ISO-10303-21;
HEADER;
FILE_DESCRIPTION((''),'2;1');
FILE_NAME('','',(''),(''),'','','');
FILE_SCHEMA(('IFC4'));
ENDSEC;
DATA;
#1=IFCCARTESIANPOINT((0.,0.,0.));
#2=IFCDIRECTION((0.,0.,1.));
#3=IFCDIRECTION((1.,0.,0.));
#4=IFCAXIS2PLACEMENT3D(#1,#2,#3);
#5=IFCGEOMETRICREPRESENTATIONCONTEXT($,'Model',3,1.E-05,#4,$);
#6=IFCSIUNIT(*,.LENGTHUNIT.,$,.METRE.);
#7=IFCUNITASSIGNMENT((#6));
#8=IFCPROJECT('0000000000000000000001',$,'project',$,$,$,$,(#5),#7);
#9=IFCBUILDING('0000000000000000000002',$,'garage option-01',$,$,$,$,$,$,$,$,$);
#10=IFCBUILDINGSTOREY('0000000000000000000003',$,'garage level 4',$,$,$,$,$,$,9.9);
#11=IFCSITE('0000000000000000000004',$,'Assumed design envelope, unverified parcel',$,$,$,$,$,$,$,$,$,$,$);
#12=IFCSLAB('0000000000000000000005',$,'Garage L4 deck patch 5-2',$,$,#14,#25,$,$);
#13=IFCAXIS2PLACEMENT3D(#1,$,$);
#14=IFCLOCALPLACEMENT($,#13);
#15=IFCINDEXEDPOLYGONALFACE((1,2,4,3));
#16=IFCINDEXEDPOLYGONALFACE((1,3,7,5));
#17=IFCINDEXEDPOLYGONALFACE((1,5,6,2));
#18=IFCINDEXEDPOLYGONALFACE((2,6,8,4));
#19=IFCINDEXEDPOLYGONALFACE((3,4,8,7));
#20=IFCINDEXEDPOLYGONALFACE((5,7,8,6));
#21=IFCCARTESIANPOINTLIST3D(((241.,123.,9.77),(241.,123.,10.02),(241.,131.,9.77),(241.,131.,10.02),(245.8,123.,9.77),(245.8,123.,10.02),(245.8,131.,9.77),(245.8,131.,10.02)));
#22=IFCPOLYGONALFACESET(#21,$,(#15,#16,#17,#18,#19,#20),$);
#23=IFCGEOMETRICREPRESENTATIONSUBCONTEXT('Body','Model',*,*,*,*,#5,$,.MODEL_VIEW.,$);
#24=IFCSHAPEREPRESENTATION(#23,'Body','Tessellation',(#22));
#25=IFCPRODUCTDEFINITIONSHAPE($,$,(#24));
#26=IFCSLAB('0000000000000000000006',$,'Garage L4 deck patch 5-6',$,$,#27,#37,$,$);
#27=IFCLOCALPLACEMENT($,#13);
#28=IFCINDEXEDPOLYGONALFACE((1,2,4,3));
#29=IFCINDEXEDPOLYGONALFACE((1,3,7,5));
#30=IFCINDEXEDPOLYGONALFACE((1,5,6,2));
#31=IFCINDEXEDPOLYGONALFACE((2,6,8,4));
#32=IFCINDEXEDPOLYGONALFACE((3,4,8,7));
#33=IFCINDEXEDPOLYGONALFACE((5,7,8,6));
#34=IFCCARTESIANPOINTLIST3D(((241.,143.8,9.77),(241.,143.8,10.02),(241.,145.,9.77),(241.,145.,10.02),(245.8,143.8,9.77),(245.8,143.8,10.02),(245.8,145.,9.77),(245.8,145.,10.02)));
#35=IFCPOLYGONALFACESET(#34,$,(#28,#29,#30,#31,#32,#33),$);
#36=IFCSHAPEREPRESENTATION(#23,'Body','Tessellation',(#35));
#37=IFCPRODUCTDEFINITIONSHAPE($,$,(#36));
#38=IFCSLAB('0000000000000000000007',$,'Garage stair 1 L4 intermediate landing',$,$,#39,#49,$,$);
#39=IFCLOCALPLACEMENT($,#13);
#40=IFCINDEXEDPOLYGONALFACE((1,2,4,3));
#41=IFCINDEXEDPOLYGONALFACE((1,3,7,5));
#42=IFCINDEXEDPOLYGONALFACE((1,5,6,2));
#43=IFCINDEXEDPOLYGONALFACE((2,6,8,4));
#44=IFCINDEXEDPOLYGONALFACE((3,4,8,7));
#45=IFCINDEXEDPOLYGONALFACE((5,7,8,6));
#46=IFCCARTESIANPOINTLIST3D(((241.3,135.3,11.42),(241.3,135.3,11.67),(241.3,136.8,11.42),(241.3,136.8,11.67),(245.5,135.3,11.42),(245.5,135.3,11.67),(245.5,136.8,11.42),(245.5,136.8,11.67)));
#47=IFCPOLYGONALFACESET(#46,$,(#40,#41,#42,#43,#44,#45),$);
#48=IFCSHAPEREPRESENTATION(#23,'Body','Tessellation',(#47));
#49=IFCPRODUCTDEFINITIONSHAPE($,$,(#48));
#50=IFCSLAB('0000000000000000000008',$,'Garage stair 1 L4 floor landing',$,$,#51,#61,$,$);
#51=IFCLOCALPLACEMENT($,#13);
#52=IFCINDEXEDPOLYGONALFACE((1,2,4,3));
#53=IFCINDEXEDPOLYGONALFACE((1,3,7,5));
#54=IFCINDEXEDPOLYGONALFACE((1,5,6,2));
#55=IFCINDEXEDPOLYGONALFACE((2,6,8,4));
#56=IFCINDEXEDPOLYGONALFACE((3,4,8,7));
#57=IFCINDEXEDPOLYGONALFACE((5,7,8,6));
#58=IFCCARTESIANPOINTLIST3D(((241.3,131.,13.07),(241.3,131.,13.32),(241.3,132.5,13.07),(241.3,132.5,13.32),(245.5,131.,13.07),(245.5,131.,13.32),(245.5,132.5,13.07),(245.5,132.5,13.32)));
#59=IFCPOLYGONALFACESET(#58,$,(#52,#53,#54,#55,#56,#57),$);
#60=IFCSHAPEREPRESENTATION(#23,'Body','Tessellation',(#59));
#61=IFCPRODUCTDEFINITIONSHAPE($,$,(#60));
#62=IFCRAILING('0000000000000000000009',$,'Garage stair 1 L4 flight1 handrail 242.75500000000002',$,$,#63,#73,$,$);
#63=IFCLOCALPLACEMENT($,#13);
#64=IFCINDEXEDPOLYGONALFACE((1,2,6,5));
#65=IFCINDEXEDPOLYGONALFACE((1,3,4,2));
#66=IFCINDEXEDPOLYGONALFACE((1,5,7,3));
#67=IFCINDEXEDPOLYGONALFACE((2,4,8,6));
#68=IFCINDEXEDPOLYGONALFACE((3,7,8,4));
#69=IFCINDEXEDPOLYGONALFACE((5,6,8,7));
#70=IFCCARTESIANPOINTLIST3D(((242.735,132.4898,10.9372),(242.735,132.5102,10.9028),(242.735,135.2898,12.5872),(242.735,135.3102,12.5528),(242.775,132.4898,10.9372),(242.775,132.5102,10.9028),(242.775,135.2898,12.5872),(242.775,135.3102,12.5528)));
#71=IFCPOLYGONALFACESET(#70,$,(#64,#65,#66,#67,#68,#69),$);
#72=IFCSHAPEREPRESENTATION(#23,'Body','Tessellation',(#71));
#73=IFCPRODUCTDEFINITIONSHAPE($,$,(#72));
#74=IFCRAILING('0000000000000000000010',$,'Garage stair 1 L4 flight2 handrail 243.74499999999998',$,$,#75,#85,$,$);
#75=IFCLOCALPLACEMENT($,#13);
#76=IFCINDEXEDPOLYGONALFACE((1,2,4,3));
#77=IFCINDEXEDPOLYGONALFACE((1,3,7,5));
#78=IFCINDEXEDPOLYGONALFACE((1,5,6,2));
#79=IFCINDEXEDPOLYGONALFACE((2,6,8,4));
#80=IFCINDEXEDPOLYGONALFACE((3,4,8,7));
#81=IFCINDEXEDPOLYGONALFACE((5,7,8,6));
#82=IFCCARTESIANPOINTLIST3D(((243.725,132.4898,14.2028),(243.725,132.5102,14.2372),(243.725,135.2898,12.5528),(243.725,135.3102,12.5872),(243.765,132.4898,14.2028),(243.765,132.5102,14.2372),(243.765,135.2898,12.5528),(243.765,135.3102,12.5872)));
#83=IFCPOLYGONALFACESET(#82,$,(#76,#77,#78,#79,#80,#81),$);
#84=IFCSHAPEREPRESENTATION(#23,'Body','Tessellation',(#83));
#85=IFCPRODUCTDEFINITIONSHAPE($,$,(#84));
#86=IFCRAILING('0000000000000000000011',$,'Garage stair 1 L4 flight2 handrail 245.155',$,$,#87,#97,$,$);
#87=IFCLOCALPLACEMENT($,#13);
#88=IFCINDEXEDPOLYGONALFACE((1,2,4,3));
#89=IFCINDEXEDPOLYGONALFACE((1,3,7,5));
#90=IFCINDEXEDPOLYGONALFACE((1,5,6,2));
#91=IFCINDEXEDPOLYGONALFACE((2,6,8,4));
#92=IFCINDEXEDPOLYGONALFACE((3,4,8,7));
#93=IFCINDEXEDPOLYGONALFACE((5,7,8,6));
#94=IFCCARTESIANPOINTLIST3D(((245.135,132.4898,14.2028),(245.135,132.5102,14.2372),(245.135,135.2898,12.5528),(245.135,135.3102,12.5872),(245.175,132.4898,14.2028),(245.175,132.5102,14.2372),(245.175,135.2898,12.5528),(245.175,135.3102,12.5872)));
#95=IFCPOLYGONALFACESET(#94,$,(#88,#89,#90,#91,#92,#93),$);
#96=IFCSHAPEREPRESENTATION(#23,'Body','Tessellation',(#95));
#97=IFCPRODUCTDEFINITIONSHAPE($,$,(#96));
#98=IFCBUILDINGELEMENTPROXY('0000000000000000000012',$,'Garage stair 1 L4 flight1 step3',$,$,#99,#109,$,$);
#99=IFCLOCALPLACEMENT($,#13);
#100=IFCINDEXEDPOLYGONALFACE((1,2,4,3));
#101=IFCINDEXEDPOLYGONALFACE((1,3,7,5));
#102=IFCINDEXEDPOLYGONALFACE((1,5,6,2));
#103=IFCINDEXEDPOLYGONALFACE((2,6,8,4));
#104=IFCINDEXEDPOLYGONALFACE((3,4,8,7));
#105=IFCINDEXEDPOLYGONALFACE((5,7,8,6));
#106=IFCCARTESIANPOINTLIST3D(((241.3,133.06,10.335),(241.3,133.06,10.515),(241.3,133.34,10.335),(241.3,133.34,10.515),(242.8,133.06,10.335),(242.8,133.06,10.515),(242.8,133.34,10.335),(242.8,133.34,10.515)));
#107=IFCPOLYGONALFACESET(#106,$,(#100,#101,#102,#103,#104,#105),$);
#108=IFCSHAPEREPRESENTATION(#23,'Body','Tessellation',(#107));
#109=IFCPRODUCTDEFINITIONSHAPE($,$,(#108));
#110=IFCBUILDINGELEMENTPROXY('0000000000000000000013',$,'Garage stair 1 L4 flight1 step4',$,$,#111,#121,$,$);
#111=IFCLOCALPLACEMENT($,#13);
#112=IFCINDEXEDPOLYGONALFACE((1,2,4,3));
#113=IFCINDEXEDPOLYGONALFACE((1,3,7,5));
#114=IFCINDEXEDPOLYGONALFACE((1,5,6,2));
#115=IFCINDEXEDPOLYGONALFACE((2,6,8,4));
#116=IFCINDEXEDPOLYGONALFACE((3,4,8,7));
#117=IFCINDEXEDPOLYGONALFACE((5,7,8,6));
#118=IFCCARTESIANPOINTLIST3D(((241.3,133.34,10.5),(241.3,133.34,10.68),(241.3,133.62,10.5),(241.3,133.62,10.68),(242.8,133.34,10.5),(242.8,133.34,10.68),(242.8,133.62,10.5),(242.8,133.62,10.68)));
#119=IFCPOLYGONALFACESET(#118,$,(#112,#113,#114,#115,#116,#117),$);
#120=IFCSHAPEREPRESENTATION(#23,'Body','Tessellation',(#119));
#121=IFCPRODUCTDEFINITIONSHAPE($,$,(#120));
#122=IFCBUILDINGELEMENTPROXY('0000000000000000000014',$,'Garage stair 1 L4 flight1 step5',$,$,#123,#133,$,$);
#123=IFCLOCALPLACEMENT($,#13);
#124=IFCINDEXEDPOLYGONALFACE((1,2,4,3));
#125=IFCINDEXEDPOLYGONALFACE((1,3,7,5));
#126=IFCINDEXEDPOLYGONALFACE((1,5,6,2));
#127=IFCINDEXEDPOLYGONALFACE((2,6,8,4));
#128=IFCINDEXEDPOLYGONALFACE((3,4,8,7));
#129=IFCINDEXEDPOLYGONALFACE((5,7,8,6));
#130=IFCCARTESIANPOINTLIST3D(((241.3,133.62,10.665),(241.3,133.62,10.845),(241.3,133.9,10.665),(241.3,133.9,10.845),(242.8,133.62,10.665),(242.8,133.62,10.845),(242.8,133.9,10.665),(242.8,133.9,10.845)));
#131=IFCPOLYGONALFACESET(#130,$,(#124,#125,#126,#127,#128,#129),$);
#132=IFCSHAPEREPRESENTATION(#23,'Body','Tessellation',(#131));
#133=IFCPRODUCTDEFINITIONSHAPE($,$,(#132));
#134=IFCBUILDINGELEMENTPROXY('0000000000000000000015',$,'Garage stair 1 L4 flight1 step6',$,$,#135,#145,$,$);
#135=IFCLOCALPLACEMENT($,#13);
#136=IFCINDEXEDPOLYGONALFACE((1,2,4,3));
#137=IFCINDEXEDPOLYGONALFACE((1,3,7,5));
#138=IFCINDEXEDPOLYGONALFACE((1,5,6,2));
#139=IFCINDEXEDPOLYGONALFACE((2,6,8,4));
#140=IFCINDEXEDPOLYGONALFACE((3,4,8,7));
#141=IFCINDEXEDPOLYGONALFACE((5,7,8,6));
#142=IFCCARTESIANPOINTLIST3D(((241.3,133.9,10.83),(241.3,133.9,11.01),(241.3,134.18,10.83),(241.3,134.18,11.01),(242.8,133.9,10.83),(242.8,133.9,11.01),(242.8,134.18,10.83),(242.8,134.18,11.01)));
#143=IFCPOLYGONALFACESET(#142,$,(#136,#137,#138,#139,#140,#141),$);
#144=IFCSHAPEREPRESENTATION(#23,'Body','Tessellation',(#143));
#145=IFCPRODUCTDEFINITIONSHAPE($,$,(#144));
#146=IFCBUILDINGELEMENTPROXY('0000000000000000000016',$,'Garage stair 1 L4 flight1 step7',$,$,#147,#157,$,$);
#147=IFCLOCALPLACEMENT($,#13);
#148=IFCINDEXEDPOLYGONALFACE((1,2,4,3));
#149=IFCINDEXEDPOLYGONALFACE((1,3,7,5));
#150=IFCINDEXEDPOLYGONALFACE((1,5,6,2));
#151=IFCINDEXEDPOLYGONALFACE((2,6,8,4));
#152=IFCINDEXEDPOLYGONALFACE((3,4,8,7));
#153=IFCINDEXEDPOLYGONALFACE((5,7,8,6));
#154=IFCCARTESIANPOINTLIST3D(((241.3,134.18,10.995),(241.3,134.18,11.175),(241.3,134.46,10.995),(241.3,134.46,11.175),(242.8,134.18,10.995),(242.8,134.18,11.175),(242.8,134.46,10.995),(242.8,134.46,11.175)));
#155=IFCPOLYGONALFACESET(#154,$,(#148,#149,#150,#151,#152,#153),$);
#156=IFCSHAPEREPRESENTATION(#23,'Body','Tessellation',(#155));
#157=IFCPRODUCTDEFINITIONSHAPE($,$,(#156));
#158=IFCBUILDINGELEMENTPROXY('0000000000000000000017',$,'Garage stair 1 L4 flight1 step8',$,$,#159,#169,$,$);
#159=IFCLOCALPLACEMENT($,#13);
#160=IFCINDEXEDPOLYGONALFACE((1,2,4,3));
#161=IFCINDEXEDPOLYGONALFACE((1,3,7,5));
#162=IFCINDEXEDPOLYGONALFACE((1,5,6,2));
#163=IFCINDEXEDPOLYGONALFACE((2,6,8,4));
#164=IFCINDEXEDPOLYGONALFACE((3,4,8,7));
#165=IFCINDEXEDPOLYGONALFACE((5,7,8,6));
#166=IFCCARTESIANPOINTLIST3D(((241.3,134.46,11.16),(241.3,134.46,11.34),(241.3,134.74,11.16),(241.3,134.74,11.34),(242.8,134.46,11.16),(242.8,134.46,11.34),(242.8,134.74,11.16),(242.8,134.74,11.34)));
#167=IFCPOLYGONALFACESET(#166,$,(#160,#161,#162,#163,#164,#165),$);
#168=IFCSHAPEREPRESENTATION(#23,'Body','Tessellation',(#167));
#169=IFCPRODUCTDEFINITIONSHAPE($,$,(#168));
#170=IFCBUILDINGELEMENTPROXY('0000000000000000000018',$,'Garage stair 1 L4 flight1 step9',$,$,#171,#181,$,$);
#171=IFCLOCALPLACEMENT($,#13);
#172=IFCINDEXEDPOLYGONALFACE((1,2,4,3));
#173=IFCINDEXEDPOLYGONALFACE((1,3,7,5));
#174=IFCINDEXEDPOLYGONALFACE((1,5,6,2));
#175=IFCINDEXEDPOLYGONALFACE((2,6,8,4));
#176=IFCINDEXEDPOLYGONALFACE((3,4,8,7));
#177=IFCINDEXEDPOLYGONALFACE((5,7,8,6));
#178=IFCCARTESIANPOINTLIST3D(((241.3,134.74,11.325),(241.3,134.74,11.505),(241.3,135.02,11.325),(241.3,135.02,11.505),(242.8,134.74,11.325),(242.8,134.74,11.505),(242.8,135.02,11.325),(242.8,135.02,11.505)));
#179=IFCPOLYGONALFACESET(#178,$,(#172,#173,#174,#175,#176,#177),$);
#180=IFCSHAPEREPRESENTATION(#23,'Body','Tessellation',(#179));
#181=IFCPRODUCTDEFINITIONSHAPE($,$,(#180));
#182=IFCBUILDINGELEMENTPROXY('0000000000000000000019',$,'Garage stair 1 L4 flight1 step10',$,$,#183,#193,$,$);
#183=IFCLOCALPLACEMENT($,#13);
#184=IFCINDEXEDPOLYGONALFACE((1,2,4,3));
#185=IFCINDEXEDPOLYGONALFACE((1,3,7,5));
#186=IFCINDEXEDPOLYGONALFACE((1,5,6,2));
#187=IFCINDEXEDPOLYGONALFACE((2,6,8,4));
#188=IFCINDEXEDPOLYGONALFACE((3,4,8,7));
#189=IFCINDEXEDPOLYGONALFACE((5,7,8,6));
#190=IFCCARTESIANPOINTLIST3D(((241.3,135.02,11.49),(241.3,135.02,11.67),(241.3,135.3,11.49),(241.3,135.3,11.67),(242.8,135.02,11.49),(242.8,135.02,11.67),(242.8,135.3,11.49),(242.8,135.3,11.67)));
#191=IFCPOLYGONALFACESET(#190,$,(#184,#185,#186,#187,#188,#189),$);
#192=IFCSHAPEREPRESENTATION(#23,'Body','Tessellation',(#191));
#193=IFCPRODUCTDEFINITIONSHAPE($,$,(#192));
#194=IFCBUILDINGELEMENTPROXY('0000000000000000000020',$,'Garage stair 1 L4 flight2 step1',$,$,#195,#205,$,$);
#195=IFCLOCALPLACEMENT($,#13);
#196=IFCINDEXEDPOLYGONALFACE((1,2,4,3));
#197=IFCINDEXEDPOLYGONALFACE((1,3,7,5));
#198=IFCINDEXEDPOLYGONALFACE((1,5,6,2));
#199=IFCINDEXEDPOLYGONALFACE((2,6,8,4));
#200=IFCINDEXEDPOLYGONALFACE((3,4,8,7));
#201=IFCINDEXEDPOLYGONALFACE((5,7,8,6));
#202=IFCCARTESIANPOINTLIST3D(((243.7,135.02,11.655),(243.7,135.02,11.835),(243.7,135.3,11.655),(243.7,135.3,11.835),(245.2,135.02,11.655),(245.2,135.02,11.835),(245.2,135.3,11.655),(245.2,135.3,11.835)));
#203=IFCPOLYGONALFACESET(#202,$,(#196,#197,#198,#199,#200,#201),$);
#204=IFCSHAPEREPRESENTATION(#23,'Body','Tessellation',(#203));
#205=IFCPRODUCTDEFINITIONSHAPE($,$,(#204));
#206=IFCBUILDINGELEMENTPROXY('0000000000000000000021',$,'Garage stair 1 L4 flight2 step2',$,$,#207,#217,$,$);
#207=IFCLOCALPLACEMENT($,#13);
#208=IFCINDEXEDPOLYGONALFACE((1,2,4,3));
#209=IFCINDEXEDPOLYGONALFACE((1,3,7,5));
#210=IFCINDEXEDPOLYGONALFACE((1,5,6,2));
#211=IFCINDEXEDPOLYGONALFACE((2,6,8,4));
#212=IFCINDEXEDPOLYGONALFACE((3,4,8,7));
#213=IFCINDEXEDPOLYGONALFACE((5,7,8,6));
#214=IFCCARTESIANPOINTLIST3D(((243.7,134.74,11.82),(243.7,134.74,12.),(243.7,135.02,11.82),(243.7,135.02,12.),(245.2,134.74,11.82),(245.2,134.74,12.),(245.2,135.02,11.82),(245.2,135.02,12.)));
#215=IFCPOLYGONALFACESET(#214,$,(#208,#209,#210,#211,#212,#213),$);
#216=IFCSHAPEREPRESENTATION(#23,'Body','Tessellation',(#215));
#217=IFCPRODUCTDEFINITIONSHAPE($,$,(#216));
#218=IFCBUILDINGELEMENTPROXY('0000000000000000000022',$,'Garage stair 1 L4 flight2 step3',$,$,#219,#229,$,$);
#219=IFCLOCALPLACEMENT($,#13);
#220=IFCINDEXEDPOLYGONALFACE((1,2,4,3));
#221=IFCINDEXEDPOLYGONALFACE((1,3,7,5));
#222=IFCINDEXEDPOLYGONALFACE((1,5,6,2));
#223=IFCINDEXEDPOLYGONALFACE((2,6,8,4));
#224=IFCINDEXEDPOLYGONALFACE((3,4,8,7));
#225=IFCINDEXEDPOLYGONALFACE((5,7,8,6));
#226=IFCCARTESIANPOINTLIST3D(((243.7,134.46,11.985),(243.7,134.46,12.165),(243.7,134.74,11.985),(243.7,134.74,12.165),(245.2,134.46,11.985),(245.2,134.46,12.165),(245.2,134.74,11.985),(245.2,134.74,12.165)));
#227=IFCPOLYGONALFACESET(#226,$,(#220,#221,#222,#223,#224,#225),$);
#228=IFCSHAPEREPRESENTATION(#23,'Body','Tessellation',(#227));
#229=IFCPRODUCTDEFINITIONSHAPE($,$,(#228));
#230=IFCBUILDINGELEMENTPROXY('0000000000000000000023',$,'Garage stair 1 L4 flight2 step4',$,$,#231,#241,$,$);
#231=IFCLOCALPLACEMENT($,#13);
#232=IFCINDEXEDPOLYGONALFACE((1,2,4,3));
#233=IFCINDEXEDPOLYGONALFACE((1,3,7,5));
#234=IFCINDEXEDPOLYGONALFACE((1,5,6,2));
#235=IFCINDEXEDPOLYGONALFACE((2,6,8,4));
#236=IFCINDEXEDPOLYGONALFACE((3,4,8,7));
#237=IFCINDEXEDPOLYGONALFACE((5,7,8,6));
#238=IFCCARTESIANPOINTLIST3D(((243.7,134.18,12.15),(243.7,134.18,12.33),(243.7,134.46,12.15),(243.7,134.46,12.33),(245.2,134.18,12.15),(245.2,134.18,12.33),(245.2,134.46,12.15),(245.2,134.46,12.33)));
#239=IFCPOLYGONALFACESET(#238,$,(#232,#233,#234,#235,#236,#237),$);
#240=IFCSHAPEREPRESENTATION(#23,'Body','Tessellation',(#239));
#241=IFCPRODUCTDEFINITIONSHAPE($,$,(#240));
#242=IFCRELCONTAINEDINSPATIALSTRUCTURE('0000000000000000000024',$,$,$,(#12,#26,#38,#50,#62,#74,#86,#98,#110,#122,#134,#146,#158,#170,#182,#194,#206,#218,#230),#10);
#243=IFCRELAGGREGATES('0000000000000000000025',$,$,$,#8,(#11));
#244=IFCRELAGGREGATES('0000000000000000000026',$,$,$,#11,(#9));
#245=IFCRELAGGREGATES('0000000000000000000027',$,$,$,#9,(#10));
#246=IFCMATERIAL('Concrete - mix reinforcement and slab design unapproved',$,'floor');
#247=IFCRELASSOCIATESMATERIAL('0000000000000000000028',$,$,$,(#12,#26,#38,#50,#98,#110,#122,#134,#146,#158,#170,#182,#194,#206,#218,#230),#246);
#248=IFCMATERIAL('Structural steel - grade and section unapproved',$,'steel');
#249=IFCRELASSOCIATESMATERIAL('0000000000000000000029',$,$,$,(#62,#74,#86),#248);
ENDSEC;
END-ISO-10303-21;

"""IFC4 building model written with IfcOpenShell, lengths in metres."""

from ifc_helpers import new_model, si_unit, frame, origin_with_axes, place, context, subcontext, project, spatial, rectangle, extrude, material, element, save


model = new_model("IFC4")

# Units and contexts
model_context = context("Model", 3, precision=1e-05, world=origin_with_axes())
body_context = subcontext(model_context, "Body", "Model", "MODEL_VIEW")
ifc_project = project(units=[si_unit("LENGTHUNIT", "METRE")], contexts=[model_context])

# Site, building, storey
site = spatial("IfcSite", under=ifc_project, Name="Assumed design envelope, unverified parcel")
building = spatial("IfcBuilding", under=site, Name="garage option-01")
storey = spatial("IfcBuildingStorey", under=building, Name="garage level 4", Elevation=9.9)

# Slabs
ifc_material_1 = material(Name="Concrete - mix reinforcement and slab design unapproved", Category="floor")
slab_1_placement = place(None, frame((243.4, 127.0, 9.77), z_axis=(0.0, 0.0, 1.0), x_axis=(1.0, 0.0, 0.0)))
element("IfcSlab", 1, at=slab_1_placement, inside=storey, material=ifc_material_1, Name="Garage L4 deck patch 5-2", context=body_context, shape_type="SweptSolid", body=[
    extrude(rectangle(XDim=4.8, YDim=8.0), origin_with_axes(), (0.0, 0.0, 1.0), 0.25),
])
slab_2_placement = place(None, frame((243.4, 144.4, 9.77), z_axis=(0.0, 0.0, 1.0), x_axis=(1.0, 0.0, 0.0)))
element("IfcSlab", 2, at=slab_2_placement, inside=storey, material=ifc_material_1, Name="Garage L4 deck patch 5-6", context=body_context, shape_type="SweptSolid", body=[
    extrude(rectangle(XDim=4.8, YDim=1.2), origin_with_axes(), (0.0, 0.0, 1.0), 0.25),
])
for number, where, z_axis, x_axis, name in (
    (3, (243.4, 136.05, 11.42), (0.0, 0.0, 1.0), (1.0, 0.0, 0.0), "Garage stair 1 L4 intermediate landing"),
    (4, (243.4, 131.75, 13.07), (0.0, 0.0, 1.0), (1.0, 0.0, 0.0), "Garage stair 1 L4 floor landing"),
):
    element("IfcSlab", number, at=place(None, frame(where, z_axis=z_axis, x_axis=x_axis)), inside=storey, material=ifc_material_1, Name=name, context=body_context, shape_type="SweptSolid", body=[
        extrude(rectangle(XDim=4.2, YDim=1.5), origin_with_axes(), (0.0, 0.0, 1.0), 0.25),
    ])

# Railings
ifc_material_2 = material(Name="Structural steel - grade and section unapproved", Category="steel")
railing_placement = place(None, frame((242.755, 132.5, 10.92), z_axis=(0.0, 0.861539, 0.507692), x_axis=(-1.0, 0.0, 0.0)))
element("IfcRailing", 5, at=railing_placement, inside=storey, material=ifc_material_2, Name="Garage stair 1 L4 flight1 handrail 242.75500000000002", context=body_context, shape_type="SweptSolid", body=[
    extrude(rectangle(XDim=0.04, YDim=0.04), origin_with_axes(), (0.0, 0.0, 1.0), 3.25),
])
for number, where, z_axis, x_axis, name in (
    (6, (243.745, 132.5, 14.22), (0.0, 0.861539, -0.507692), (-1.0, 0.0, 0.0), "Garage stair 1 L4 flight2 handrail 243.74499999999998"),
    (7, (245.155, 132.5, 14.22), (0.0, 0.861539, -0.507692), (-1.0, 0.0, 0.0), "Garage stair 1 L4 flight2 handrail 245.155"),
):
    element("IfcRailing", number, at=place(None, frame(where, z_axis=z_axis, x_axis=x_axis)), inside=storey, material=ifc_material_2, Name=name, context=body_context, shape_type="SweptSolid", body=[
        extrude(rectangle(XDim=0.04, YDim=0.04), origin_with_axes(), (0.0, 0.0, 1.0), 3.25),
    ])

# Building element proxies
for number, where, z_axis, x_axis, name in (
    (8, (242.05, 133.2, 10.335), (0.0, 0.0, 1.0), (1.0, 0.0, 0.0), "Garage stair 1 L4 flight1 step3"),
    (9, (242.05, 133.48, 10.5), (0.0, 0.0, 1.0), (1.0, 0.0, 0.0), "Garage stair 1 L4 flight1 step4"),
    (10, (242.05, 133.76, 10.665), (0.0, 0.0, 1.0), (1.0, 0.0, 0.0), "Garage stair 1 L4 flight1 step5"),
    (11, (242.05, 134.04, 10.83), (0.0, 0.0, 1.0), (1.0, 0.0, 0.0), "Garage stair 1 L4 flight1 step6"),
    (12, (242.05, 134.32, 10.995), (0.0, 0.0, 1.0), (1.0, 0.0, 0.0), "Garage stair 1 L4 flight1 step7"),
    (13, (242.05, 134.6, 11.16), (0.0, 0.0, 1.0), (1.0, 0.0, 0.0), "Garage stair 1 L4 flight1 step8"),
    (14, (242.05, 134.88, 11.325), (0.0, 0.0, 1.0), (1.0, 0.0, 0.0), "Garage stair 1 L4 flight1 step9"),
    (15, (242.05, 135.16, 11.49), (0.0, 0.0, 1.0), (1.0, 0.0, 0.0), "Garage stair 1 L4 flight1 step10"),
    (16, (244.45, 135.16, 11.655), (0.0, 0.0, 1.0), (1.0, 0.0, 0.0), "Garage stair 1 L4 flight2 step1"),
    (17, (244.45, 134.88, 11.82), (0.0, 0.0, 1.0), (1.0, 0.0, 0.0), "Garage stair 1 L4 flight2 step2"),
    (18, (244.45, 134.6, 11.985), (0.0, 0.0, 1.0), (1.0, 0.0, 0.0), "Garage stair 1 L4 flight2 step3"),
    (19, (244.45, 134.32, 12.15), (0.0, 0.0, 1.0), (1.0, 0.0, 0.0), "Garage stair 1 L4 flight2 step4"),
):
    element("IfcBuildingElementProxy", number, at=place(None, frame(where, z_axis=z_axis, x_axis=x_axis)), inside=storey, material=ifc_material_1, Name=name, context=body_context, shape_type="SweptSolid", body=[
        extrude(rectangle(XDim=1.5, YDim=0.28), origin_with_axes(), (0.0, 0.0, 1.0), 0.18),
    ])

save(model, "model.ifc")
